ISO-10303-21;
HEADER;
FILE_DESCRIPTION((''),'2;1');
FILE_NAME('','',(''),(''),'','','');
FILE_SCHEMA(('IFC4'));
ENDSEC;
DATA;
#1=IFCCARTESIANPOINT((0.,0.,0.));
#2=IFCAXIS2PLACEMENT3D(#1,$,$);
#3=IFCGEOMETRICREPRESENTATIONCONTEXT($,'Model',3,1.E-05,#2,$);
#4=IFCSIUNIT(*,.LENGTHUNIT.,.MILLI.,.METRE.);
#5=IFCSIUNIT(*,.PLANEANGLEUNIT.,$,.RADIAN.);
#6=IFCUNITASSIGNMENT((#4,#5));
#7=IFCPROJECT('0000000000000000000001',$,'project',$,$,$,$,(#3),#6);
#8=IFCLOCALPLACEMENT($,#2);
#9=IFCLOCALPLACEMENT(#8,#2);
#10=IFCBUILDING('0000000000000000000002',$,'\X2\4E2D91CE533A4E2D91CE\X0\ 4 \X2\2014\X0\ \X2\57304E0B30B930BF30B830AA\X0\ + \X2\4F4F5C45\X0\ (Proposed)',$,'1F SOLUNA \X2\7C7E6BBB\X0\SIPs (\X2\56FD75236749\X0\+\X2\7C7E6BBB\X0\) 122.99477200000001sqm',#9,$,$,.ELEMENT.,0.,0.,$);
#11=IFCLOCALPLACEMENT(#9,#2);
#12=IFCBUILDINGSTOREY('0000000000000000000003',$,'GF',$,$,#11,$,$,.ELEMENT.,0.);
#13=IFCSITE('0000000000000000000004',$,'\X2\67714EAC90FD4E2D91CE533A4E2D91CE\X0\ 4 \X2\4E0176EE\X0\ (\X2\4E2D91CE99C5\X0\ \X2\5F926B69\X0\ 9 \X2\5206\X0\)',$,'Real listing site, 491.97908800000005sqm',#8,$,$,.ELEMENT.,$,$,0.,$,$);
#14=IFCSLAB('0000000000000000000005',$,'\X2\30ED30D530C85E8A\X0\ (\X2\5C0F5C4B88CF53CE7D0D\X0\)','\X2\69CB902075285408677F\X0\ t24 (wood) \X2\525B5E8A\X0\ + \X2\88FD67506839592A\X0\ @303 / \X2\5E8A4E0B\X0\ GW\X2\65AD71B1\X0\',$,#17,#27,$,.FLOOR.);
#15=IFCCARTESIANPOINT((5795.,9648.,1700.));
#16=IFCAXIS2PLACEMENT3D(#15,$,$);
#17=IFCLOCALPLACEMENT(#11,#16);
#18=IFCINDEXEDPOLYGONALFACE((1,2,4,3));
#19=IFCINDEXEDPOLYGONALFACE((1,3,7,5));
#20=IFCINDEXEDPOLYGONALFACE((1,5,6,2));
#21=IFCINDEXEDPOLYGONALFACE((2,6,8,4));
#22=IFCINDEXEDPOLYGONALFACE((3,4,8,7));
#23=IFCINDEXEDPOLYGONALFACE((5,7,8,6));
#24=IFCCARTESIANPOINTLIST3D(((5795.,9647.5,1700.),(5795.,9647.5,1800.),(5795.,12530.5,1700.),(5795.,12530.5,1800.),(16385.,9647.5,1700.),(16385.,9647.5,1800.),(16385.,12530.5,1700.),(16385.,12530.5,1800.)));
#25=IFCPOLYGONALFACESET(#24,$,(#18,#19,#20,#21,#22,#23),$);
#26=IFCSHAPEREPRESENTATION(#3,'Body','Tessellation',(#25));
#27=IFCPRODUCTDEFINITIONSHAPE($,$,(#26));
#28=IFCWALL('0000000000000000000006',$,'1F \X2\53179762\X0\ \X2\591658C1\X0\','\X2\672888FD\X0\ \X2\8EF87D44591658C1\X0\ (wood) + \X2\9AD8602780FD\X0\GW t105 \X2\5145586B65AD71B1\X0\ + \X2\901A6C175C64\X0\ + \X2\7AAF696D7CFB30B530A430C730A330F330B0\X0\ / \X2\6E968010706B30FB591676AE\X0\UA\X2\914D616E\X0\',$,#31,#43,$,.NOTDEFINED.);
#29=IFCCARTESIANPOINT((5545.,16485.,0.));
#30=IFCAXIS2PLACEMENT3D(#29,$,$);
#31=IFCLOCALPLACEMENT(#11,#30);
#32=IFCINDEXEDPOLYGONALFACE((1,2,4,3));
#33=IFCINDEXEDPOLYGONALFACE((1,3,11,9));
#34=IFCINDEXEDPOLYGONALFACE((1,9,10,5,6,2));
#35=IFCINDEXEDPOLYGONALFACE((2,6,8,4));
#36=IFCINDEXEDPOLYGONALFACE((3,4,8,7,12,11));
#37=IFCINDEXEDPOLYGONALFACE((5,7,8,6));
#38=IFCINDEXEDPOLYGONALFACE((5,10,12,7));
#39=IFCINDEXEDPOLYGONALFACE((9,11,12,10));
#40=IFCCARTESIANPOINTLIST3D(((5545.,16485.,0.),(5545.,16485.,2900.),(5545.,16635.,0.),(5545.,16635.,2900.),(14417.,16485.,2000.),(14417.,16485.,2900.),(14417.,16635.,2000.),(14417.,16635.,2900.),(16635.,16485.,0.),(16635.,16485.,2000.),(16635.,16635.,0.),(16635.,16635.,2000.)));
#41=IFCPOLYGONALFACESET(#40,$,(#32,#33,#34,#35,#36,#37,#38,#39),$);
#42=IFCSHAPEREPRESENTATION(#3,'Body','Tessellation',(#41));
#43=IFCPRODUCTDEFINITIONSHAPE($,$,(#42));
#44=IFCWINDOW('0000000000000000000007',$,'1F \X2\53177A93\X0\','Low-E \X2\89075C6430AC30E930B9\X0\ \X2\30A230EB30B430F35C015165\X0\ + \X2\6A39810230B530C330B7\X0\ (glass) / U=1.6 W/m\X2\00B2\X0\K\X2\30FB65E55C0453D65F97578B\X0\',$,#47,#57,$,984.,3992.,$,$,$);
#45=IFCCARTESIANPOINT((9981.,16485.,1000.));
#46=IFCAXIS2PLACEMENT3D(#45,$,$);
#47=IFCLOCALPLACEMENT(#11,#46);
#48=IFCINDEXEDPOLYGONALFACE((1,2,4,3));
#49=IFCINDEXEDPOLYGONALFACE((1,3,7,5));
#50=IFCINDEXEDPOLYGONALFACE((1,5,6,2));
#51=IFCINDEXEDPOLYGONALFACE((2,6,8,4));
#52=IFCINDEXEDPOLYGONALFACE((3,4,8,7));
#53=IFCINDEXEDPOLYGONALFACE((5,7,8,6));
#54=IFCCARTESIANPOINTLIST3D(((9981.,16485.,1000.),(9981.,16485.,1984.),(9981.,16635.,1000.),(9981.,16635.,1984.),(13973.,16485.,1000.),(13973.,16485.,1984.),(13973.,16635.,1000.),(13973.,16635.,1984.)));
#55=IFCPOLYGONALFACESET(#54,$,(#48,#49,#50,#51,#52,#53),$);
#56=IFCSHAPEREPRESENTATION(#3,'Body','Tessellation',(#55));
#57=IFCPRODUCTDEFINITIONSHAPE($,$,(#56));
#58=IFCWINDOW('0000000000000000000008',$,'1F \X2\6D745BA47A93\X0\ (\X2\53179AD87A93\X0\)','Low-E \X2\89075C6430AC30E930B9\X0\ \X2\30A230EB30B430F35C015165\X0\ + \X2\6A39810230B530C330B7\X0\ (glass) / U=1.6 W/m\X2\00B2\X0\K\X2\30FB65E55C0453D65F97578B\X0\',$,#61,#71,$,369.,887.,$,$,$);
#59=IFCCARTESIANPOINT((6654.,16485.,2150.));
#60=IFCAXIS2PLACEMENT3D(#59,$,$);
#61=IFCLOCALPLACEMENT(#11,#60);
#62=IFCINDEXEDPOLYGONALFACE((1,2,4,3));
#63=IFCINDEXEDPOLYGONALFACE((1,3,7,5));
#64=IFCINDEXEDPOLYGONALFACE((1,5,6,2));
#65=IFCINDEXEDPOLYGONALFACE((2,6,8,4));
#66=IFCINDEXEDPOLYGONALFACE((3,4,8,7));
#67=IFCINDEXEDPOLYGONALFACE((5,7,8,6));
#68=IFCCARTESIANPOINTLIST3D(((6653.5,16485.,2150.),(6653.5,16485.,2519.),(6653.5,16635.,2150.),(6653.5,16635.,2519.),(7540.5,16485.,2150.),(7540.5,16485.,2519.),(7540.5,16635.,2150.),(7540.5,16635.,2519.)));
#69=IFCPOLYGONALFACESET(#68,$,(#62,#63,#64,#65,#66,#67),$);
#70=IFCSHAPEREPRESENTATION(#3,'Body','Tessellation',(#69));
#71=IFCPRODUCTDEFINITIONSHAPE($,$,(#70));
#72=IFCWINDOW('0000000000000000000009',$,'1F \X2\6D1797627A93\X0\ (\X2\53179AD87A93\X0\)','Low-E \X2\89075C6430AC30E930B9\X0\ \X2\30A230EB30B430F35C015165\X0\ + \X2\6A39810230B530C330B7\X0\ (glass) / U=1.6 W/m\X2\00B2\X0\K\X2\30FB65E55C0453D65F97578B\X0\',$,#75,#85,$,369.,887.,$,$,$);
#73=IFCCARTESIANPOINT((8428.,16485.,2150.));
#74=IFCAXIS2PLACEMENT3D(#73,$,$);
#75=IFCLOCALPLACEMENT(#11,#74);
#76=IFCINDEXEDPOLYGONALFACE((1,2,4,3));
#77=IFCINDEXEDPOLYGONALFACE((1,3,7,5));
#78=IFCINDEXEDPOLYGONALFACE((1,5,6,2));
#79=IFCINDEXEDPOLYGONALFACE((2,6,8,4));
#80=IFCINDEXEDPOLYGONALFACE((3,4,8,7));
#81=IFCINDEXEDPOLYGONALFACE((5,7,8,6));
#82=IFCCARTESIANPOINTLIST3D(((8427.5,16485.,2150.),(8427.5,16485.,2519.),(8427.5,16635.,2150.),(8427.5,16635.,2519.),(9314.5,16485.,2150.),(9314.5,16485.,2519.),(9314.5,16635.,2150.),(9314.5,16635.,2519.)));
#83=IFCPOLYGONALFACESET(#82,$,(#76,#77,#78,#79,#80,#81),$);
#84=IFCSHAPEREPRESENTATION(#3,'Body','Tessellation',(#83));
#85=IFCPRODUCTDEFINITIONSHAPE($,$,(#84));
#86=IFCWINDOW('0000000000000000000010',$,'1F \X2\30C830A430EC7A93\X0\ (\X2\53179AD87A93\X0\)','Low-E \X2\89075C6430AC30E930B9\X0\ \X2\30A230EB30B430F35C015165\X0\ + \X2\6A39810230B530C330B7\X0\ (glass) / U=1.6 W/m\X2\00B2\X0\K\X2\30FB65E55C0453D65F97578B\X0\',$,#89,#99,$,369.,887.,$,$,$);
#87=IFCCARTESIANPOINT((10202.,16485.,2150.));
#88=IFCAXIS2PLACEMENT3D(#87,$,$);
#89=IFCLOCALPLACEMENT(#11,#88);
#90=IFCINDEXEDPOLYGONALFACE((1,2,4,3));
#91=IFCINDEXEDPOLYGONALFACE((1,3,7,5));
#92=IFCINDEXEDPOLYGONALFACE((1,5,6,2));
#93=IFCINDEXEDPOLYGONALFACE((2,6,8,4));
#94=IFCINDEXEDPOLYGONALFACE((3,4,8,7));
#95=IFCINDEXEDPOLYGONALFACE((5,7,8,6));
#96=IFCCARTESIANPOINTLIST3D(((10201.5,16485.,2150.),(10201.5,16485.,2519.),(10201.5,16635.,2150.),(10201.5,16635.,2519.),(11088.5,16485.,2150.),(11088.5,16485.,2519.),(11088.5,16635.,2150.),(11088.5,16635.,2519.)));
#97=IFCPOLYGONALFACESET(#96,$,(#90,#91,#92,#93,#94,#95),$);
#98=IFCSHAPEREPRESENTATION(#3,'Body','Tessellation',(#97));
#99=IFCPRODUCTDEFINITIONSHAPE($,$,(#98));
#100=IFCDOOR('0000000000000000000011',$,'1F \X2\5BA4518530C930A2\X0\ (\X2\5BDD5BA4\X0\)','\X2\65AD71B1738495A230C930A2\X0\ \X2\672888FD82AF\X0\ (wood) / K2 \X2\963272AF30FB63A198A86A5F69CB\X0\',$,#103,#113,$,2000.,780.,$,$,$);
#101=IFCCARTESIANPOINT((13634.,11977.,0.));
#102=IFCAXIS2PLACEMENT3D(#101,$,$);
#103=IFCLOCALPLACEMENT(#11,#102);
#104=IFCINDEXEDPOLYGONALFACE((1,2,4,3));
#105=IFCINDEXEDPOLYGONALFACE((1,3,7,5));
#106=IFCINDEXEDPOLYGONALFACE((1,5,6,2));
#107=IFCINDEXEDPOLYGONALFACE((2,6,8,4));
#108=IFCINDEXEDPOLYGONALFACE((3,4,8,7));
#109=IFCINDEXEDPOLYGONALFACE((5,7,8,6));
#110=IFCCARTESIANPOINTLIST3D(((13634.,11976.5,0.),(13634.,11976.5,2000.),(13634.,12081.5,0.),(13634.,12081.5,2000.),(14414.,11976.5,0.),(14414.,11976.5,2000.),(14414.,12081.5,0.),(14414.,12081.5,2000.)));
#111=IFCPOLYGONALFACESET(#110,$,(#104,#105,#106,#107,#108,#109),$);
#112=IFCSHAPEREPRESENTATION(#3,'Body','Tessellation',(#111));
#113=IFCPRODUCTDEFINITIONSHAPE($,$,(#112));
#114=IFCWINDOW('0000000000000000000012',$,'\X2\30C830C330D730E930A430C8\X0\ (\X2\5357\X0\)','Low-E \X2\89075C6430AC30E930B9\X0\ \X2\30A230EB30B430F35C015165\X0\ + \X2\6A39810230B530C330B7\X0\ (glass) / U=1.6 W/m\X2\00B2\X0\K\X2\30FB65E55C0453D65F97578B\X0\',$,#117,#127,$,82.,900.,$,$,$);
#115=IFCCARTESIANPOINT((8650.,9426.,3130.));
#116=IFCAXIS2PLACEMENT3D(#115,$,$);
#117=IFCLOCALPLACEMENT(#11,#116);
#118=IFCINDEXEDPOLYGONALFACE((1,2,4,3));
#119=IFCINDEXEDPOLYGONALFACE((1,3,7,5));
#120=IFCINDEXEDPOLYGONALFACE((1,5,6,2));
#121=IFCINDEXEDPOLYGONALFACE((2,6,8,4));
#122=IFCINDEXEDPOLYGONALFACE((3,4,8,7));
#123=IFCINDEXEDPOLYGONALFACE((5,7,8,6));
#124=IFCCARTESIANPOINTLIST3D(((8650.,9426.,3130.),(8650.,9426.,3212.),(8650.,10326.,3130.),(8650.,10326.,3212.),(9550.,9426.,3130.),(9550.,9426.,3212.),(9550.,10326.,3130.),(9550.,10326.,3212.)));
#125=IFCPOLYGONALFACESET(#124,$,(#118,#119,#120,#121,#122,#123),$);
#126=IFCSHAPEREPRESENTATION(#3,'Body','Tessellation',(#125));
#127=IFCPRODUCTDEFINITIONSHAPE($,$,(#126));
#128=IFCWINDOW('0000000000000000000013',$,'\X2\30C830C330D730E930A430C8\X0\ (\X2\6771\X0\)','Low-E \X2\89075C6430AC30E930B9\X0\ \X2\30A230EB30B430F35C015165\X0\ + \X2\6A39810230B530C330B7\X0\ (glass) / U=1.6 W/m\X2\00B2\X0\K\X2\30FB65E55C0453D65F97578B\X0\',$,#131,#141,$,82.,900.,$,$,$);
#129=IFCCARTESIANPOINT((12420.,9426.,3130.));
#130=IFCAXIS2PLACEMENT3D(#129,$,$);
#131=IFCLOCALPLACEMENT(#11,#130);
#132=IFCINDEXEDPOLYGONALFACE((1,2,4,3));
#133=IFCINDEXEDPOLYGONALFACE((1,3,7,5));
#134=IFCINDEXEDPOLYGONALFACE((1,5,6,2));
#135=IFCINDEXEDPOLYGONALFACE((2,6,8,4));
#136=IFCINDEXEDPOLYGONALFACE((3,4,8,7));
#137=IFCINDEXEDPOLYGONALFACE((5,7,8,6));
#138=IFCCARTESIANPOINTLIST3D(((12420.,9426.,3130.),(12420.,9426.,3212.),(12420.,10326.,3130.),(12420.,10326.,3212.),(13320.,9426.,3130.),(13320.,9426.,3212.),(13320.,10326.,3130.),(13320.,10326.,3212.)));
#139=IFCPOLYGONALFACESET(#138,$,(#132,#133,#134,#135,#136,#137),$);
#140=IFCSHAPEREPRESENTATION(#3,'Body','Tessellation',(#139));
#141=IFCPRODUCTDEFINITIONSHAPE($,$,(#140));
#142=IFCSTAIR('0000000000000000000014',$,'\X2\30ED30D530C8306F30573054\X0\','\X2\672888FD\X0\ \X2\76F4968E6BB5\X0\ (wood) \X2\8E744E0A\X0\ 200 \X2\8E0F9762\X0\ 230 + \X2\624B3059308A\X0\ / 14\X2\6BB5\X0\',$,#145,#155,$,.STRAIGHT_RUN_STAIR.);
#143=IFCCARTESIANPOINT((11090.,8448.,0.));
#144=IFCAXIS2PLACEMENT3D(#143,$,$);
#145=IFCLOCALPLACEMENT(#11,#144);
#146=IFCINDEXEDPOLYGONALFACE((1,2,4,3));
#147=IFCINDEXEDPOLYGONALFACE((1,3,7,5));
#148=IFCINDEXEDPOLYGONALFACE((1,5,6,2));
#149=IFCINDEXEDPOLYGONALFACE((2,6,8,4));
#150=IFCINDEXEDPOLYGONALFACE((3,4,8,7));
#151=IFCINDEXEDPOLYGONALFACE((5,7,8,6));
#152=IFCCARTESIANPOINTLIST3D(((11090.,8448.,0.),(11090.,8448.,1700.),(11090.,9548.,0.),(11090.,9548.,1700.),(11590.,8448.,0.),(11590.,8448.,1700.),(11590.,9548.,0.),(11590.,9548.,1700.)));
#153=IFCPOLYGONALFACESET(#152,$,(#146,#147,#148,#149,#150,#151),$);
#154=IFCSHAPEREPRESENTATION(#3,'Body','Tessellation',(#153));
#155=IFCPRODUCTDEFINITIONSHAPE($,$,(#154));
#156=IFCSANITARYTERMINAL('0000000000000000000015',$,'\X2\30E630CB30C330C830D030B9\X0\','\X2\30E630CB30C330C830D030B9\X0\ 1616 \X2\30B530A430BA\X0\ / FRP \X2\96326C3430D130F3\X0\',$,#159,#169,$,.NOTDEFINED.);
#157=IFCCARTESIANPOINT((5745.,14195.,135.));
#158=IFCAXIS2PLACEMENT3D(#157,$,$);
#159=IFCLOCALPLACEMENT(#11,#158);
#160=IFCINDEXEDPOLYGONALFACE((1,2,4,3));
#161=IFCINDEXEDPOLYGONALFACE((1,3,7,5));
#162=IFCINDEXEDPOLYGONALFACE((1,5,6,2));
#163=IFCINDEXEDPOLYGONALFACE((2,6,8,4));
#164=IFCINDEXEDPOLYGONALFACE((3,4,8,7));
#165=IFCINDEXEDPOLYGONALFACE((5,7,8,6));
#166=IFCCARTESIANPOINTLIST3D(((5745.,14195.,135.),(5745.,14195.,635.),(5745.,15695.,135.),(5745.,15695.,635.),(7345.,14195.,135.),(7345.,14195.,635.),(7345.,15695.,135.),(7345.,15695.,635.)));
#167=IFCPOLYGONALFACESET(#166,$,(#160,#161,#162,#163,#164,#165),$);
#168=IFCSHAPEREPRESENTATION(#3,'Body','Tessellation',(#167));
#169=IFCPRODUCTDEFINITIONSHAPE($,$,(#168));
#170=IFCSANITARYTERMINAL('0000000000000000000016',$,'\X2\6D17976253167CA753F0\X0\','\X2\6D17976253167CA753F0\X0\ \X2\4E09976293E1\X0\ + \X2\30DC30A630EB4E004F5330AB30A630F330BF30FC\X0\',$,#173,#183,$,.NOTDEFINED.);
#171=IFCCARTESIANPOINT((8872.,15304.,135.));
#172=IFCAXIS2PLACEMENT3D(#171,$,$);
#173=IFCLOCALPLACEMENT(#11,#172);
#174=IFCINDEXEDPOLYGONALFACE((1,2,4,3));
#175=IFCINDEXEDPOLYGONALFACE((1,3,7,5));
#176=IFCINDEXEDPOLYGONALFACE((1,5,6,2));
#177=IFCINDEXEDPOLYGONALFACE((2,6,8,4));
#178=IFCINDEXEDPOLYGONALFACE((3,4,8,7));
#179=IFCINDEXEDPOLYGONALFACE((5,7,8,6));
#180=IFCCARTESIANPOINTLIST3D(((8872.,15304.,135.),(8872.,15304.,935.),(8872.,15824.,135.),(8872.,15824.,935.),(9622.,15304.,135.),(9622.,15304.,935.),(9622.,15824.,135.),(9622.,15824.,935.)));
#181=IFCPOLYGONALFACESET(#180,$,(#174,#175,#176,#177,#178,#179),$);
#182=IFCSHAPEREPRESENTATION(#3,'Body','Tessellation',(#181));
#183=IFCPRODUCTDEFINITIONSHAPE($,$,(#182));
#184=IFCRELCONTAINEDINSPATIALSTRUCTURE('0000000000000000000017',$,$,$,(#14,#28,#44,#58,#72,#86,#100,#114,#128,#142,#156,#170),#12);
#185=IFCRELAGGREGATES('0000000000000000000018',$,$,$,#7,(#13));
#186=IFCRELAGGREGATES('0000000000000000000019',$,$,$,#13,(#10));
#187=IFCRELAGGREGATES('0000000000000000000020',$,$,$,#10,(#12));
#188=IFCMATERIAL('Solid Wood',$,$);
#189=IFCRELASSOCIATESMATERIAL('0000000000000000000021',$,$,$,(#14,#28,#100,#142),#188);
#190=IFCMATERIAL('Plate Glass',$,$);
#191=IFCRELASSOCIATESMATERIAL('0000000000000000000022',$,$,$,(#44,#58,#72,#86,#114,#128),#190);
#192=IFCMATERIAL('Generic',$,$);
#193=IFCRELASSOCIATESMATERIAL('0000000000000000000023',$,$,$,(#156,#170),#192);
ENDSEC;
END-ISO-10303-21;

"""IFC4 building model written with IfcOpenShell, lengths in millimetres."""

from ifc_helpers import new_model, si_unit, frame, frame_2d, origin, place, context, project, spatial, rectangle, extrude, material, element, fill, save


model = new_model("IFC4")

# Units and contexts
model_context = context("Model", 3, precision=1e-05, world=origin())
ifc_project = project(units=[si_unit("LENGTHUNIT", "METRE", prefix="MILLI"), si_unit("PLANEANGLEUNIT", "RADIAN")], contexts=[model_context])

# Site, building, storey
site_placement = place(None, origin())
site = spatial("IfcSite", under=ifc_project, at=site_placement, Name="東京都中野区中野 4 丁目 (中野駅 徒歩 9 分)", ObjectType="Real listing site, 491.97908800000005sqm", CompositionType="ELEMENT", RefElevation=0.0)
building_placement = place(site_placement, origin())
building = spatial("IfcBuilding", under=site, at=building_placement, Name="中野区中野 4 — 地下スタジオ + 住居 (Proposed)", ObjectType="1F SOLUNA 籾殻SIPs (国産杉+籾殻) 122.99477200000001sqm", CompositionType="ELEMENT", ElevationOfRefHeight=0.0, ElevationOfTerrain=0.0)
storey_placement = place(building_placement, origin())
storey = spatial("IfcBuildingStorey", under=building, at=storey_placement, Name="GF", CompositionType="ELEMENT", Elevation=0.0)

# Slab
ifc_material_1 = material(Name="Solid Wood")
slab_placement = place(storey_placement, frame((5795.0, 9648.0, 1700.0)))
element("IfcSlab", 1, at=slab_placement, inside=storey, material=ifc_material_1, Name="ロフト床 (小屋裏収納)", Description="構造用合板 t24 (wood) 剛床 + 製材根太 @303 / 床下 GW断熱", PredefinedType="FLOOR", context=model_context, shape_type="SweptSolid", body=[
    extrude(rectangle(XDim=10590.0, YDim=2883.0, at=frame_2d((5295.0, 1441.0))), frame((5795.0, 9648.0, 1700.0)), (0.0, 0.0, 1.0), 100.0),
])

# Wall, openings, windows
wall_1_placement = place(storey_placement, frame((5545.0, 16485.0, 0.0)))
wall_1 = element("IfcWall", 2, at=wall_1_placement, inside=storey, material=ifc_material_1, Name="1F 北面 外壁", Description="木製 軸組外壁 (wood) + 高性能GW t105 充填断熱 + 通気層 + 窯業系サイディング / 準耐火・外皮UA配慮", PredefinedType="NOTDEFINED", context=model_context, shape_type="SweptSolid", body=[
    extrude(rectangle(XDim=11090.0, YDim=150.0, at=frame_2d((5545.0, 75.0))), frame((5545.0, 16485.0, 0.0)), (0.0, 0.0, 1.0), 2900.0),
])
opening_1_placement = place(storey_placement, frame((9981.0, 16485.0, 1000.0)))
opening_1 = element("IfcOpeningElement", 3, at=opening_1_placement, cuts=wall_1, PredefinedType="NOTDEFINED", context=model_context, shape_type="SweptSolid", body=[
    extrude(rectangle(XDim=3992.0, YDim=150.0, at=frame_2d((1996.0, 75.0))), frame((9981.0, 16485.0, 1000.0)), (0.0, 0.0, 1.0), 984.0),
])
opening_2_placement = place(storey_placement, frame((6654.0, 16485.0, 2150.0)))
opening_2 = element("IfcOpeningElement", 4, at=opening_2_placement, cuts=wall_1, PredefinedType="NOTDEFINED", context=model_context, shape_type="SweptSolid", body=[
    extrude(rectangle(XDim=887.0, YDim=150.0, at=frame_2d((443.0, 75.0))), frame((6654.0, 16485.0, 2150.0)), (0.0, 0.0, 1.0), 369.0),
])
opening_3_placement = place(storey_placement, frame((8428.0, 16485.0, 2150.0)))
opening_3 = element("IfcOpeningElement", 5, at=opening_3_placement, cuts=wall_1, PredefinedType="NOTDEFINED", context=model_context, shape_type="SweptSolid", body=[
    extrude(rectangle(XDim=887.0, YDim=150.0, at=frame_2d((443.0, 75.0))), frame((8428.0, 16485.0, 2150.0)), (0.0, 0.0, 1.0), 369.0),
])
opening_4_placement = place(storey_placement, frame((10202.0, 16485.0, 2150.0)))
opening_4 = element("IfcOpeningElement", 6, at=opening_4_placement, cuts=wall_1, PredefinedType="NOTDEFINED", context=model_context, shape_type="SweptSolid", body=[
    extrude(rectangle(XDim=887.0, YDim=150.0, at=frame_2d((443.0, 75.0))), frame((10202.0, 16485.0, 2150.0)), (0.0, 0.0, 1.0), 369.0),
])
ifc_material_2 = material(Name="Plate Glass")
window_1_placement = place(storey_placement, frame((9981.0, 16485.0, 1000.0)))
window_1 = element("IfcWindow", 7, at=window_1_placement, inside=storey, material=ifc_material_2, Name="1F 北窓", Description="Low-E 複層ガラス アルゴン封入 + 樹脂サッシ (glass) / U=1.6 W/m²K・日射取得型", OverallHeight=984.0, OverallWidth=3992.0, context=model_context, shape_type="SweptSolid", body=[
    extrude(rectangle(XDim=3992.0, YDim=150.0, at=frame_2d((1996.0, 75.0))), frame((9981.0, 16485.0, 1000.0)), (0.0, 0.0, 1.0), 984.0),
])
fill(opening_1, window_1)
window_2_placement = place(storey_placement, frame((6654.0, 16485.0, 2150.0)))
window_2 = element("IfcWindow", 8, at=window_2_placement, inside=storey, material=ifc_material_2, Name="1F 浴室窓 (北高窓)", Description="Low-E 複層ガラス アルゴン封入 + 樹脂サッシ (glass) / U=1.6 W/m²K・日射取得型", OverallHeight=369.0, OverallWidth=887.0, context=model_context, shape_type="SweptSolid", body=[
    extrude(rectangle(XDim=887.0, YDim=150.0, at=frame_2d((443.0, 75.0))), frame((6654.0, 16485.0, 2150.0)), (0.0, 0.0, 1.0), 369.0),
])
fill(opening_2, window_2)
window_3_placement = place(storey_placement, frame((8428.0, 16485.0, 2150.0)))
window_3 = element("IfcWindow", 9, at=window_3_placement, inside=storey, material=ifc_material_2, Name="1F 洗面窓 (北高窓)", Description="Low-E 複層ガラス アルゴン封入 + 樹脂サッシ (glass) / U=1.6 W/m²K・日射取得型", OverallHeight=369.0, OverallWidth=887.0, context=model_context, shape_type="SweptSolid", body=[
    extrude(rectangle(XDim=887.0, YDim=150.0, at=frame_2d((443.0, 75.0))), frame((8428.0, 16485.0, 2150.0)), (0.0, 0.0, 1.0), 369.0),
])
fill(opening_3, window_3)
window_4_placement = place(storey_placement, frame((10202.0, 16485.0, 2150.0)))
window_4 = element("IfcWindow", 10, at=window_4_placement, inside=storey, material=ifc_material_2, Name="1F トイレ窓 (北高窓)", Description="Low-E 複層ガラス アルゴン封入 + 樹脂サッシ (glass) / U=1.6 W/m²K・日射取得型", OverallHeight=369.0, OverallWidth=887.0, context=model_context, shape_type="SweptSolid", body=[
    extrude(rectangle(XDim=887.0, YDim=150.0, at=frame_2d((443.0, 75.0))), frame((10202.0, 16485.0, 2150.0)), (0.0, 0.0, 1.0), 369.0),
])
fill(opening_4, window_4)

# Door
door_1_placement = place(storey_placement, frame((13634.0, 11977.0, 0.0)))
element("IfcDoor", 11, at=door_1_placement, inside=storey, material=ifc_material_1, Name="1F 室内ドア (寝室)", Description="断熱玄関ドア 木製芯 (wood) / K2 防犯・採風機構", OverallHeight=2000.0, OverallWidth=780.0, context=model_context, shape_type="SweptSolid", body=[
    extrude(rectangle(XDim=780.0, YDim=105.0, at=frame_2d((390.0, 52.0))), frame((13634.0, 11977.0, 0.0)), (0.0, 0.0, 1.0), 2000.0),
])

# Windows
window_5_placement = place(storey_placement, frame((8650.0, 9426.0, 3130.0)))
element("IfcWindow", 12, at=window_5_placement, inside=storey, material=ifc_material_2, Name="トップライト (南)", Description="Low-E 複層ガラス アルゴン封入 + 樹脂サッシ (glass) / U=1.6 W/m²K・日射取得型", OverallHeight=82.0, OverallWidth=900.0, context=model_context, shape_type="SweptSolid", body=[
    extrude(rectangle(XDim=900.0, YDim=900.0, at=frame_2d((450.0, 450.0))), frame((8650.0, 9426.0, 3130.0)), (0.0, 0.0, 1.0), 82.0),
])
window_6_placement = place(storey_placement, frame((12420.0, 9426.0, 3130.0)))
element("IfcWindow", 13, at=window_6_placement, inside=storey, material=ifc_material_2, Name="トップライト (東)", Description="Low-E 複層ガラス アルゴン封入 + 樹脂サッシ (glass) / U=1.6 W/m²K・日射取得型", OverallHeight=82.0, OverallWidth=900.0, context=model_context, shape_type="SweptSolid", body=[
    extrude(rectangle(XDim=900.0, YDim=900.0, at=frame_2d((450.0, 450.0))), frame((12420.0, 9426.0, 3130.0)), (0.0, 0.0, 1.0), 82.0),
])

# Stair
stair_placement = place(storey_placement, frame((11090.0, 8448.0, 0.0)))
element("IfcStair", 14, at=stair_placement, inside=storey, material=ifc_material_1, Name="ロフトはしご", Description="木製 直階段 (wood) 蹴上 200 踏面 230 + 手すり / 14段", PredefinedType="STRAIGHT_RUN_STAIR", context=model_context, shape_type="SweptSolid", body=[
    extrude(rectangle(XDim=500.0, YDim=1100.0, at=frame_2d((250.0, 550.0))), frame((11090.0, 8448.0, 0.0)), (0.0, 0.0, 1.0), 1700.0),
])

# Sanitary terminals
ifc_material_3 = material(Name="Generic")
sanitary_terminal_1_placement = place(storey_placement, frame((5745.0, 14195.0, 135.0)))
element("IfcSanitaryTerminal", 15, at=sanitary_terminal_1_placement, inside=storey, material=ifc_material_3, Name="ユニットバス", Description="ユニットバス 1616 サイズ / FRP 防水パン", PredefinedType="NOTDEFINED", context=model_context, shape_type="SweptSolid", body=[
    extrude(rectangle(XDim=1600.0, YDim=1500.0, at=frame_2d((800.0, 750.0))), frame((5745.0, 14195.0, 135.0)), (0.0, 0.0, 1.0), 500.0),
])
sanitary_terminal_2_placement = place(storey_placement, frame((8872.0, 15304.0, 135.0)))
element("IfcSanitaryTerminal", 16, at=sanitary_terminal_2_placement, inside=storey, material=ifc_material_3, Name="洗面化粧台", Description="洗面化粧台 三面鏡 + ボウル一体カウンター", PredefinedType="NOTDEFINED", context=model_context, shape_type="SweptSolid", body=[
    extrude(rectangle(XDim=750.0, YDim=520.0, at=frame_2d((375.0, 260.0))), frame((8872.0, 15304.0, 135.0)), (0.0, 0.0, 1.0), 800.0),
])

save(model, "model.ifc")
